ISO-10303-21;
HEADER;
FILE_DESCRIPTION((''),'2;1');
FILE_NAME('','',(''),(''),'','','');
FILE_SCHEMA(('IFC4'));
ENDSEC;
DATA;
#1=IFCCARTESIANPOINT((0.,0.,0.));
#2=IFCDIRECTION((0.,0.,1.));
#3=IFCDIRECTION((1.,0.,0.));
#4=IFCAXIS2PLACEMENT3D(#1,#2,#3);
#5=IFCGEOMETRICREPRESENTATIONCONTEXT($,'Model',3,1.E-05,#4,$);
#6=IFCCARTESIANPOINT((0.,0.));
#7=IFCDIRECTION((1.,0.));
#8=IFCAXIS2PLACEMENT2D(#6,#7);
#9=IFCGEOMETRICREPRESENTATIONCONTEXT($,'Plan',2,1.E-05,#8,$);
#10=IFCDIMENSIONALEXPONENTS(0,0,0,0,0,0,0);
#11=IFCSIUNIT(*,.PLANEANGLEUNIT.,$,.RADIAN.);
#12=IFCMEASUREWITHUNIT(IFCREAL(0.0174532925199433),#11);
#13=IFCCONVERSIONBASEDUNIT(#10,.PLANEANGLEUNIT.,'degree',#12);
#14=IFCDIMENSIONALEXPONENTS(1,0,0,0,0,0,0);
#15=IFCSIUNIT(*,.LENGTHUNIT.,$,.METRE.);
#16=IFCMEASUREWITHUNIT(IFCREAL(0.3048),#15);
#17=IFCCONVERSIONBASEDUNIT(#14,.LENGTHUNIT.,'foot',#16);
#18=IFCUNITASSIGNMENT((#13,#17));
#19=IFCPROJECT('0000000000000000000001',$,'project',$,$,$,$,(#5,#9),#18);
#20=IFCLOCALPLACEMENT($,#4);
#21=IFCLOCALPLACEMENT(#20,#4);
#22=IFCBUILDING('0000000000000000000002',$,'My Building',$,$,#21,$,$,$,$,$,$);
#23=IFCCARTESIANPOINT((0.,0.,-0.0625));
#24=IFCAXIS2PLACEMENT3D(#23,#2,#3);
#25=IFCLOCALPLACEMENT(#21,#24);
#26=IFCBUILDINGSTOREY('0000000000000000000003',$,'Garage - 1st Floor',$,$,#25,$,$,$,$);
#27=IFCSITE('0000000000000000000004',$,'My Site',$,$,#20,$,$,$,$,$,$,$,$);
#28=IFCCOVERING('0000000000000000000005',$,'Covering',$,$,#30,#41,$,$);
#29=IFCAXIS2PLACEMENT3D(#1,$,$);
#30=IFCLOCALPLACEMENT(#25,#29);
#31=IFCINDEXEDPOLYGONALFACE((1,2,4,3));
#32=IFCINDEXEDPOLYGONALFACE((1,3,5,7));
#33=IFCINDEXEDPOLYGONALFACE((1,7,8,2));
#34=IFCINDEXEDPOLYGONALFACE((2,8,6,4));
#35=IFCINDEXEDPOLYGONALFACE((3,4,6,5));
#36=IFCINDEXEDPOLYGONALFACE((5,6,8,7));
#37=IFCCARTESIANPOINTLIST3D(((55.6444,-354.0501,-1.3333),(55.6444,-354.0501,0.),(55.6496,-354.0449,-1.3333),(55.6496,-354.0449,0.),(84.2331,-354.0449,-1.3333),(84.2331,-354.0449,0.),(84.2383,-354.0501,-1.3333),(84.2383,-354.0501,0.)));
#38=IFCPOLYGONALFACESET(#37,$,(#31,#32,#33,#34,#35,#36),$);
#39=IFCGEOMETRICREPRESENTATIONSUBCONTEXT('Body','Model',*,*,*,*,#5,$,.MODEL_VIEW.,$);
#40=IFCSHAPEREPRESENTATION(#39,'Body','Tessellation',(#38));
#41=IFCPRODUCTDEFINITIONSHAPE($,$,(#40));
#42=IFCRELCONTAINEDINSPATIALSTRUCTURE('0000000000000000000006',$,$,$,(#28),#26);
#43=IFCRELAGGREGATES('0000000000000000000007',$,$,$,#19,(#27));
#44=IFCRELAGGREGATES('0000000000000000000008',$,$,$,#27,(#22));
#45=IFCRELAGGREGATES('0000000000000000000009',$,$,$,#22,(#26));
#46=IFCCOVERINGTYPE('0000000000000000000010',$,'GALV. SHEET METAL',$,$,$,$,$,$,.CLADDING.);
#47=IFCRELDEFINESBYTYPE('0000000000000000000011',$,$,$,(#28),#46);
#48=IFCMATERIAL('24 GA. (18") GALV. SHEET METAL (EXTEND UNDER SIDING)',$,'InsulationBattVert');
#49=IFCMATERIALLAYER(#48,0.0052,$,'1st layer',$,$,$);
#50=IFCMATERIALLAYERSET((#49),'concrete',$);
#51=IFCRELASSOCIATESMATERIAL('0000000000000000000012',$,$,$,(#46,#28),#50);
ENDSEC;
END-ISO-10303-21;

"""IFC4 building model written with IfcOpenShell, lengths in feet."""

from ifc_helpers import new_model, entity, si_unit, converted_unit, frame, origin_with_axes, origin_2d_with_axis, place, context, subcontext, project, spatial, line, indexed_curve, outline, extrude, material, layer, layer_set, layer_usage, type_object, element, save


model = new_model("IFC4")

# Units and contexts
model_context = context("Model", 3, precision=1e-05, world=origin_with_axes())
plan_context = context("Plan", 2, precision=1e-05, world=origin_2d_with_axis())
body_context = subcontext(model_context, "Body", "Model", "MODEL_VIEW")
ifc_project = project(units=[converted_unit("PLANEANGLEUNIT", "degree", entity("IfcReal", 0.0174532925199433), si_unit("PLANEANGLEUNIT", "RADIAN"), dimensions=[0, 0, 0, 0, 0, 0, 0]), converted_unit("LENGTHUNIT", "foot", entity("IfcReal", 0.3048), si_unit("LENGTHUNIT", "METRE"), dimensions=[1, 0, 0, 0, 0, 0, 0])], contexts=[model_context, plan_context])

# Site, building, storey
site_placement = place(None, origin_with_axes())
site = spatial("IfcSite", under=ifc_project, at=site_placement, Name="My Site")
building_placement = place(site_placement, origin_with_axes())
building = spatial("IfcBuilding", under=site, at=building_placement, Name="My Building")
storey_placement = place(building_placement, frame((0.0, 0.0, -0.0625), z_axis=(0.0, 0.0, 1.0), x_axis=(1.0, 0.0, 0.0)))
storey = spatial("IfcBuildingStorey", under=building, at=storey_placement, Name="Garage - 1st Floor")

# Covering
ifc_material_1 = material(Name="24 GA. (18\") GALV. SHEET METAL (EXTEND UNDER SIDING)", Category="InsulationBattVert")
ifc_layer_1 = layer(ifc_material_1, 0.0052, Name="1st layer")
ifc_layer_set_1 = layer_set([ifc_layer_1], Name="concrete")
ifc_layer_usage_1 = layer_usage(ifc_layer_set_1, "AXIS2", "POSITIVE", 0.0)
covering_type_1 = type_object("IfcCoveringType", Name="GALV. SHEET METAL", PredefinedType="CLADDING", material=ifc_layer_set_1)
covering_1_placement = place(storey_placement, frame((84.2331, -354.0449, -1.3333), z_axis=(0.0, 0.0, 1.0), x_axis=(-1.0, 0.0, 0.0)))
element("IfcCovering", 1, at=covering_1_placement, inside=storey, type_object=covering_type_1, material=ifc_layer_usage_1, Name="Covering", context=body_context, shape_type="SweptSolid", body=[
    extrude(outline(indexed_curve([(0.0, 0.0), (-0.0052, 0.0052), (28.5887, 0.0052), (28.5835, 0.0)], segments=[line(1, 2, 3, 4, 1)])), origin_with_axes(), (0.0, 0.0, 1.0), 1.3333),
])

save(model, "model.ifc")
